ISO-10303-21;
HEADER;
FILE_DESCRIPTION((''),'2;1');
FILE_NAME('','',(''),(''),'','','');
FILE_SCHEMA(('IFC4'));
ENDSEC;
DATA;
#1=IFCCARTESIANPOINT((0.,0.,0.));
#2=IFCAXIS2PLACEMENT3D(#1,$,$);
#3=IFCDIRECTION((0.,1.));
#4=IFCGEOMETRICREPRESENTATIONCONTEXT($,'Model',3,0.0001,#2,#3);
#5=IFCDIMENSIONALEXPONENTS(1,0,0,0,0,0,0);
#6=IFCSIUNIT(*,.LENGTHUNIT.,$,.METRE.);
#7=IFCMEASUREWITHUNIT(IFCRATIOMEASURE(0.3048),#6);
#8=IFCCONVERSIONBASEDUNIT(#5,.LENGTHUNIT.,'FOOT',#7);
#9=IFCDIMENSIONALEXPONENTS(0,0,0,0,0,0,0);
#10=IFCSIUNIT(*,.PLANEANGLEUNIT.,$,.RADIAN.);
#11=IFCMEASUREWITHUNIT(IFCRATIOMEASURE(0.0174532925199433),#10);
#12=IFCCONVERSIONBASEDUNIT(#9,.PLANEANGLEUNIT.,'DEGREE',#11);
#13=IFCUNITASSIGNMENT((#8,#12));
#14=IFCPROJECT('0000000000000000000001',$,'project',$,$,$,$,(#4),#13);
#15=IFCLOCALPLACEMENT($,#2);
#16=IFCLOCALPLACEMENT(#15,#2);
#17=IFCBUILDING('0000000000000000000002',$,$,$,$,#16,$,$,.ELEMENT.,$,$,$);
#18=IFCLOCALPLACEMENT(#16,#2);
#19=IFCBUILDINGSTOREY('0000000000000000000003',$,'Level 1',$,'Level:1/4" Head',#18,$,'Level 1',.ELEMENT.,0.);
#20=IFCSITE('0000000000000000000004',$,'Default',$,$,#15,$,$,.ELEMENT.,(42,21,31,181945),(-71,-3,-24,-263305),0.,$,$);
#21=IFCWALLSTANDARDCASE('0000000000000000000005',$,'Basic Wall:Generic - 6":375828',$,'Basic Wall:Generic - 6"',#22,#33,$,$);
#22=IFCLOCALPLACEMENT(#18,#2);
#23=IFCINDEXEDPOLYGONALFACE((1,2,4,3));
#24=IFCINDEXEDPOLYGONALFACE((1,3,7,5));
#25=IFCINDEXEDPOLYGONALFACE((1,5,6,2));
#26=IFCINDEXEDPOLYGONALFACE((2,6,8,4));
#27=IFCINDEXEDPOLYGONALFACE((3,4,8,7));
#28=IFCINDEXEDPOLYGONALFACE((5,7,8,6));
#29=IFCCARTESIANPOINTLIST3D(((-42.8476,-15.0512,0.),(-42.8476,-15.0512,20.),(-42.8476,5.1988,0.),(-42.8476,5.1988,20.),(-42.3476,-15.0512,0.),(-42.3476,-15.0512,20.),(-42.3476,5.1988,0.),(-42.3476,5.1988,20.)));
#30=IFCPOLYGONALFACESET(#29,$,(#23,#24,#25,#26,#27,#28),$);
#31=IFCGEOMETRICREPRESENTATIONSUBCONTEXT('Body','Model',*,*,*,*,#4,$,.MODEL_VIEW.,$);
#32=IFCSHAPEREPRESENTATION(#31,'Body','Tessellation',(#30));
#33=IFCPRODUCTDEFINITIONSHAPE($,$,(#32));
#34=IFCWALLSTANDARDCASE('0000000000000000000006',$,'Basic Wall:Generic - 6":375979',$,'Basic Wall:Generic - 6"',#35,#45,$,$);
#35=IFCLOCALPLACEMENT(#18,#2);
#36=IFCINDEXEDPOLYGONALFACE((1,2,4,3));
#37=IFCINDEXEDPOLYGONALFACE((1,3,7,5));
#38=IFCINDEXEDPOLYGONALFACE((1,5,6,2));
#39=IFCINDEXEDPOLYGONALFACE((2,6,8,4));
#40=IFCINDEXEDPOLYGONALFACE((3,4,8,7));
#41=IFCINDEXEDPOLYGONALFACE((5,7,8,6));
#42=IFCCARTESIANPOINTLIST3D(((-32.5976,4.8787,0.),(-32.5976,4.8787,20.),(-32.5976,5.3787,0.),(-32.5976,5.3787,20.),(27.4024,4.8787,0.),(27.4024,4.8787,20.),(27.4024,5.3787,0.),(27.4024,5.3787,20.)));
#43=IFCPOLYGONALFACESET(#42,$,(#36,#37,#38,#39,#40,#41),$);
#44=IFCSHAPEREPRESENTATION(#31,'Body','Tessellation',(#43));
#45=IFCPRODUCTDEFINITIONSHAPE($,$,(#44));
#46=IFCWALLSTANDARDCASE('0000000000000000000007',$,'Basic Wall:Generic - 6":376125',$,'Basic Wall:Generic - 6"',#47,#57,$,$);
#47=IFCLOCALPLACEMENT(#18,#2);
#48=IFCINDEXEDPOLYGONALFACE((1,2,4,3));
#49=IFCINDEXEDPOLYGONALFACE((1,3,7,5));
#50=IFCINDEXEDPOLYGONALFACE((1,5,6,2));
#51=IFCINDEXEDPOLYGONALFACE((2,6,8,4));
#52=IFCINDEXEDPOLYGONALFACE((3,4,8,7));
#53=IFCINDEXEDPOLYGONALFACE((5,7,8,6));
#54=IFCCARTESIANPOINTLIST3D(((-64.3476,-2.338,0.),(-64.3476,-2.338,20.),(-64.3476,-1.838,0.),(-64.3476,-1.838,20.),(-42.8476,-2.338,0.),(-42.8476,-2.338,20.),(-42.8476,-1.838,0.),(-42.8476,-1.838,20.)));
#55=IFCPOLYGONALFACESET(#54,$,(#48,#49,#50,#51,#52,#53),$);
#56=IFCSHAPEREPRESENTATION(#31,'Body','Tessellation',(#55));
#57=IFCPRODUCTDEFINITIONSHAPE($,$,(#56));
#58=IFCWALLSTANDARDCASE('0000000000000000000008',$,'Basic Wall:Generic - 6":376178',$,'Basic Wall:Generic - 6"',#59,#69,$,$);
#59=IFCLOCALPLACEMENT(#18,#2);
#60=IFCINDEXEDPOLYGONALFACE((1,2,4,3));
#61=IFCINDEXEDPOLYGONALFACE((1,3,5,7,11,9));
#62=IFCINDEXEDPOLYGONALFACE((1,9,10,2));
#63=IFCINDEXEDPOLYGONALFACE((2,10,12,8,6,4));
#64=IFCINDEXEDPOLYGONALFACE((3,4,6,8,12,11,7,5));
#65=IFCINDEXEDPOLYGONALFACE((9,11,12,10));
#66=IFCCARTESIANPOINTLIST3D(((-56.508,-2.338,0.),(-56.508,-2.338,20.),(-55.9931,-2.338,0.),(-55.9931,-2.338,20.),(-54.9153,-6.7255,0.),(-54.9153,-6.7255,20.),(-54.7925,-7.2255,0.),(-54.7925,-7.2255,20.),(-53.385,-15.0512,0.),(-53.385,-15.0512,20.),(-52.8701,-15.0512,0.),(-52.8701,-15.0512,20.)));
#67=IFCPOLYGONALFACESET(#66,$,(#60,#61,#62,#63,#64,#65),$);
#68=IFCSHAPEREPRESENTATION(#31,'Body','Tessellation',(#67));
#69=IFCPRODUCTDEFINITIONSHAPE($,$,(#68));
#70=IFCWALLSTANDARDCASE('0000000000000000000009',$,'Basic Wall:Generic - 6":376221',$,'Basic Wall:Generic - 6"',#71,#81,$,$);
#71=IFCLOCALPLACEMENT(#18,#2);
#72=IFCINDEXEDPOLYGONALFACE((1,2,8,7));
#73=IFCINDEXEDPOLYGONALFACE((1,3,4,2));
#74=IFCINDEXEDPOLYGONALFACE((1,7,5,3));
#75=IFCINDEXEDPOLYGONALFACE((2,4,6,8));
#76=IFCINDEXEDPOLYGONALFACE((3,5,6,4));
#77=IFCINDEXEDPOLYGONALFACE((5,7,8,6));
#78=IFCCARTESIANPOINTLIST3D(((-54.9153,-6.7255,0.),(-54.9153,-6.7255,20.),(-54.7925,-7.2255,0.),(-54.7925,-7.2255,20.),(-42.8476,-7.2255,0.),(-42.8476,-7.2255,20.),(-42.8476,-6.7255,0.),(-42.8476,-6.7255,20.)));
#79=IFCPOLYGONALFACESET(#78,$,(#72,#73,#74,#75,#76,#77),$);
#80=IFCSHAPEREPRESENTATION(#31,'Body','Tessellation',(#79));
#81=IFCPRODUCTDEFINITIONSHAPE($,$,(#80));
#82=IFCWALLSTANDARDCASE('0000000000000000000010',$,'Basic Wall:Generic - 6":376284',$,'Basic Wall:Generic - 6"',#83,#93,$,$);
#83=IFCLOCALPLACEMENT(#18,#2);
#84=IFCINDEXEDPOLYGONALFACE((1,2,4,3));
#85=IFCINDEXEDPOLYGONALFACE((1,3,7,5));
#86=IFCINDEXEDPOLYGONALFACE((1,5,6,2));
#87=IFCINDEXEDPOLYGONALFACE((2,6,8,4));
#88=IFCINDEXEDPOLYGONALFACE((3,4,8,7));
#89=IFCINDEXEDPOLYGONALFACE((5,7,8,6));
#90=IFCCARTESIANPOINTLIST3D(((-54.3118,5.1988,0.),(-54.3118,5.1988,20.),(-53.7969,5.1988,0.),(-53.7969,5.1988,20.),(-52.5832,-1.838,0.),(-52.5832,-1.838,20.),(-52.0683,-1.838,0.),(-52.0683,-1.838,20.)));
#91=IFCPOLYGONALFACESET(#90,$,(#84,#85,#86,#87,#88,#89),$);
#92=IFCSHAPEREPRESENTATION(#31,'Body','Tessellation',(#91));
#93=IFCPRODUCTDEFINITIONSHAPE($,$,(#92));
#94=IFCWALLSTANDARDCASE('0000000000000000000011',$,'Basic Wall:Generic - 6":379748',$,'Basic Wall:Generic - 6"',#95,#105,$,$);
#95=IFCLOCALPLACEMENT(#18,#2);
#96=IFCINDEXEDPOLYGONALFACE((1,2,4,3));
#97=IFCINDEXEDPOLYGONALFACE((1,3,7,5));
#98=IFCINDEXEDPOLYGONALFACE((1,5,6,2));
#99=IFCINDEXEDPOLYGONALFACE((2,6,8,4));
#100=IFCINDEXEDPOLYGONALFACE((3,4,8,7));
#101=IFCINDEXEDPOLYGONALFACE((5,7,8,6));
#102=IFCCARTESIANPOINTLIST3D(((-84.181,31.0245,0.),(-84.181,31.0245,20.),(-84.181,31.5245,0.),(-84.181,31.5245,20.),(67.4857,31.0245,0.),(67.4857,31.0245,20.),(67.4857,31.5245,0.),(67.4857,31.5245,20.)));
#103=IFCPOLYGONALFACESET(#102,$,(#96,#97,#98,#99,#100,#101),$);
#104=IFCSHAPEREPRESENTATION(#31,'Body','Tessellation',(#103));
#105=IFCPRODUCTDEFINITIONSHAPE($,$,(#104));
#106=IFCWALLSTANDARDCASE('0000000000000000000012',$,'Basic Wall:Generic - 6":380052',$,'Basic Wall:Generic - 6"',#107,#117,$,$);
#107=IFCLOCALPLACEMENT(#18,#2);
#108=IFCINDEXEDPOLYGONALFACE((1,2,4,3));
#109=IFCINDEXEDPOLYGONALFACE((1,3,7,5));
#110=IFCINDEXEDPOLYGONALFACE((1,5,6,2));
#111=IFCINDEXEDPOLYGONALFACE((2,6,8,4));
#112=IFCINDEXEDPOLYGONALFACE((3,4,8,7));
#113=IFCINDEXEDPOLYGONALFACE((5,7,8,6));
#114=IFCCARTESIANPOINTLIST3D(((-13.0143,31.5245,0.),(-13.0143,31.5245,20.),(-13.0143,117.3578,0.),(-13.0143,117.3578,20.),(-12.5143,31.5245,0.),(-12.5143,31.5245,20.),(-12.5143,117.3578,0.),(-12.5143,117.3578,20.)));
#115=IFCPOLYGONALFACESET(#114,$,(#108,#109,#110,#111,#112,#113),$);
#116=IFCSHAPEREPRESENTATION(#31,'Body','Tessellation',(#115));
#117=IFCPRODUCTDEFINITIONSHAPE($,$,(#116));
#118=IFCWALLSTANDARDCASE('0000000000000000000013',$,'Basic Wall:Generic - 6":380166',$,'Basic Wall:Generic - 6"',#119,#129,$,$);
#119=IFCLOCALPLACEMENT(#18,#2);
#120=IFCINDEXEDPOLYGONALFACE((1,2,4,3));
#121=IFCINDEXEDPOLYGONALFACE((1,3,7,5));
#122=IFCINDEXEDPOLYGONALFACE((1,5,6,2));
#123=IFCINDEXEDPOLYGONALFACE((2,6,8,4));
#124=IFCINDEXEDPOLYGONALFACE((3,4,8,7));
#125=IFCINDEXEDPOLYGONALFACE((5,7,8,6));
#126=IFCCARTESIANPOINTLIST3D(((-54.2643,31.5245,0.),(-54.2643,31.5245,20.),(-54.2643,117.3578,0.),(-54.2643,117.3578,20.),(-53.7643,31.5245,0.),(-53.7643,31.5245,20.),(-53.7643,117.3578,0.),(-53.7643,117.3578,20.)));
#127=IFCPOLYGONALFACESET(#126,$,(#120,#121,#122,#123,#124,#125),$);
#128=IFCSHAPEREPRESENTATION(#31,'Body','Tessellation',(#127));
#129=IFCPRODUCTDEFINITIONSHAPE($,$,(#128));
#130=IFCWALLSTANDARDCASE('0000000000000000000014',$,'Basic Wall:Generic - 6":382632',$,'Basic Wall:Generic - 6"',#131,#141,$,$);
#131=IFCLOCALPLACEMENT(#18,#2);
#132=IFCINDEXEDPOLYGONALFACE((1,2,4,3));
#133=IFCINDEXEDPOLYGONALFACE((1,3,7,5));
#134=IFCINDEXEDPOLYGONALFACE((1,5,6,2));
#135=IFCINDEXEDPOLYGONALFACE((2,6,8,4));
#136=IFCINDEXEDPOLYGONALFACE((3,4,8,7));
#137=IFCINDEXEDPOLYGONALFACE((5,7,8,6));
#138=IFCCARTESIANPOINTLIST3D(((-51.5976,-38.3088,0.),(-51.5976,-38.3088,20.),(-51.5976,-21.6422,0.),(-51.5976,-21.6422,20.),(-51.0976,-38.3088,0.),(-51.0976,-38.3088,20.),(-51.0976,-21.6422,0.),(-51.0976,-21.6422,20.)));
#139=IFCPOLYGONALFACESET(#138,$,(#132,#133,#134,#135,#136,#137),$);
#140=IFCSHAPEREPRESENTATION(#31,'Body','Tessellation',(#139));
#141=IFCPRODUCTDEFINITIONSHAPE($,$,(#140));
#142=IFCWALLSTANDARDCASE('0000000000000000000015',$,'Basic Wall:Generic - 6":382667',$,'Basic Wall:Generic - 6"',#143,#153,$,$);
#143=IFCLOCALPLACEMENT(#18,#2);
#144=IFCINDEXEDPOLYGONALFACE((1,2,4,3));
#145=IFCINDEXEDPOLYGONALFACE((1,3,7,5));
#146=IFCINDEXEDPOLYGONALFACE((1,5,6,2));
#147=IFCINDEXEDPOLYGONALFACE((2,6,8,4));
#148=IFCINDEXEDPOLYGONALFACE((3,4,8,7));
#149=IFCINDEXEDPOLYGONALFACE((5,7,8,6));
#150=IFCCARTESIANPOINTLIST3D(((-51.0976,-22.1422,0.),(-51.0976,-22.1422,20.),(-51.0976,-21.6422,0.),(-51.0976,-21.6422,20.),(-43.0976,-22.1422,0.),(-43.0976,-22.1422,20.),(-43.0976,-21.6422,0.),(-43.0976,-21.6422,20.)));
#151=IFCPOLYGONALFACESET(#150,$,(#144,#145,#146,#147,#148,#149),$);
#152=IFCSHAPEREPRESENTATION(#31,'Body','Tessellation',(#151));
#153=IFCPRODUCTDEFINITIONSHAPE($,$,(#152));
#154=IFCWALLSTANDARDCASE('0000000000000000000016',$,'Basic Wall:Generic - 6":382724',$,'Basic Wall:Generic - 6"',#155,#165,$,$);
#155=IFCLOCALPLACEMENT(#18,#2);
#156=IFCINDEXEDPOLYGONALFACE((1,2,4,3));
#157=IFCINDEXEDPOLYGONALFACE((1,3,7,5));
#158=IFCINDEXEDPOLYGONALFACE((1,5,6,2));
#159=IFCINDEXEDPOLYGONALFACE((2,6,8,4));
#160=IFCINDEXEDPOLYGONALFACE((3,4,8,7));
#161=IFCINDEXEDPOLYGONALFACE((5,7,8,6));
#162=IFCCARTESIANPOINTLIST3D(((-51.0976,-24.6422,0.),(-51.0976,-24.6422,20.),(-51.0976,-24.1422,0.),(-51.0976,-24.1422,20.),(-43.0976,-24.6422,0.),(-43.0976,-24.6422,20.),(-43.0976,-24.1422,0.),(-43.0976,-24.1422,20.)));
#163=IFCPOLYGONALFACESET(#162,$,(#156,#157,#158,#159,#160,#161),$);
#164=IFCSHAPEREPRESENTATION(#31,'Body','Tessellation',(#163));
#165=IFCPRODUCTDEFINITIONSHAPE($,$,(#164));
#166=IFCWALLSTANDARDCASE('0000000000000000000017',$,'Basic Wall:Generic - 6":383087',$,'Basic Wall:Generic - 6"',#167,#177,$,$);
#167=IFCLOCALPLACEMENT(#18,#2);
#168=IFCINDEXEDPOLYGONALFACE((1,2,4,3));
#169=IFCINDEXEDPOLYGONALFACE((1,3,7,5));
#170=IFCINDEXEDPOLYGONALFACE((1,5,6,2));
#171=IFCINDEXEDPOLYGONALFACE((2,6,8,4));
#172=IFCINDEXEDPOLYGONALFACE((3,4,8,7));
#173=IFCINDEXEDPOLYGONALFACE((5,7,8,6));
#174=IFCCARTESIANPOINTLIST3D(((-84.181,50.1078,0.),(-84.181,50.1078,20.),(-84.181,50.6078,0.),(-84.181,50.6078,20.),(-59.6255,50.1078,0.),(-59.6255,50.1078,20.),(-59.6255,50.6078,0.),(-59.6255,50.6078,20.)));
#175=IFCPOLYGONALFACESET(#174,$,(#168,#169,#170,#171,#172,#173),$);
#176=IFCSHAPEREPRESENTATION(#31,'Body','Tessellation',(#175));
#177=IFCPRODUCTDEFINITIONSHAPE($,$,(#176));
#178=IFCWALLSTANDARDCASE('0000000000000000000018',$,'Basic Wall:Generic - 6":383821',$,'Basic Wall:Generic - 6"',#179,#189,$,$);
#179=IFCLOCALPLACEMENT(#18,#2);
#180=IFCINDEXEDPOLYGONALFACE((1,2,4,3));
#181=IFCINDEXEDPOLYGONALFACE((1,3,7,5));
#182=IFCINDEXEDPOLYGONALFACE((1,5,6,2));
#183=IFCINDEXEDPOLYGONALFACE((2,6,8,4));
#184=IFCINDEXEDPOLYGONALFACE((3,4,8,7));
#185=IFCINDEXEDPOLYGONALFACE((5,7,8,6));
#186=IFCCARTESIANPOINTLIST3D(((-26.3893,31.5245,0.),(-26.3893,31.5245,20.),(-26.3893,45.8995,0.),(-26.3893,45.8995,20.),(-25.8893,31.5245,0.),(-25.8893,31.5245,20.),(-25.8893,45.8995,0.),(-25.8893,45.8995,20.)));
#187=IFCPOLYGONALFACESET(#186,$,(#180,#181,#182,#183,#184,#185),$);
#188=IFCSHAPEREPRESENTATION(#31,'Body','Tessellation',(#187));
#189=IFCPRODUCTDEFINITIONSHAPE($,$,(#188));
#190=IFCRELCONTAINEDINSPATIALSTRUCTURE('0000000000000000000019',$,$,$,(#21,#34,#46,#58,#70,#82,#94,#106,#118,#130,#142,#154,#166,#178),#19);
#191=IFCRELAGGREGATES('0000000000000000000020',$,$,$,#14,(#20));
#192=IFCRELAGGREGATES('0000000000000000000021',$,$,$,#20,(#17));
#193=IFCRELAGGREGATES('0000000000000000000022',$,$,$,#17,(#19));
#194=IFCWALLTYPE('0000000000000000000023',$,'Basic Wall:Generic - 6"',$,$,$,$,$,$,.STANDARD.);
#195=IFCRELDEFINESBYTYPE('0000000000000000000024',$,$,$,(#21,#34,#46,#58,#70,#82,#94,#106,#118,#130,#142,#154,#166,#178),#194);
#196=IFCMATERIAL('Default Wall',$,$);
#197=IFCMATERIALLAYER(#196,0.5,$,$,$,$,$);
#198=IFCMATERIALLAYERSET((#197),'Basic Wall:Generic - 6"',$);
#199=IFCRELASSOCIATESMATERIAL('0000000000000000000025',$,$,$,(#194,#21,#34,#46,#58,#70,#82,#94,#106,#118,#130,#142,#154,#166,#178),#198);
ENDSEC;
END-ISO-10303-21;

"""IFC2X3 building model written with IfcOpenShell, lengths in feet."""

from ifc_helpers import new_model, entity, si_unit, converted_unit, direction, frame, frame_2d, origin, place, context, subcontext, project, spatial, polyline, rectangle, outline, extrude, material, layer, layer_set, layer_usage, type_object, element, save


model = new_model("IFC2X3")

# Units and contexts
model_context = context("Model", 3, precision=0.0001, world=origin(), true_north=direction((0.0, 1.0)))
body_context = subcontext(model_context, "Body", "Model", "MODEL_VIEW")
ifc_project = project(units=[converted_unit("LENGTHUNIT", "FOOT", entity("IfcRatioMeasure", 0.3048), si_unit("LENGTHUNIT", "METRE"), dimensions=[1, 0, 0, 0, 0, 0, 0]), converted_unit("PLANEANGLEUNIT", "DEGREE", entity("IfcRatioMeasure", 0.0174532925199433), si_unit("PLANEANGLEUNIT", "RADIAN"), dimensions=[0, 0, 0, 0, 0, 0, 0])], contexts=[model_context])

# Site, building, storey
site_placement = place(None, origin())
site = spatial("IfcSite", under=ifc_project, at=site_placement, Name="Default", CompositionType="ELEMENT", RefLatitude=(42, 21, 31, 181945), RefLongitude=(-71, -3, -24, -263305), RefElevation=0.0)
building_placement = place(site_placement, origin())
building = spatial("IfcBuilding", under=site, at=building_placement, CompositionType="ELEMENT")
storey_placement = place(building_placement, origin())
storey = spatial("IfcBuildingStorey", under=building, at=storey_placement, Name="Level 1", ObjectType="Level:1/4\" Head", LongName="Level 1", CompositionType="ELEMENT", Elevation=0.0)

# Walls
ifc_material = material(Name="Default Wall")
ifc_layer_1 = layer(ifc_material, 0.5)
ifc_layer_set_1 = layer_set([ifc_layer_1], Name="Basic Wall:Generic - 6\"")
wall_type_1 = type_object("IfcWallType", Name="Basic Wall:Generic - 6\"", PredefinedType="STANDARD", material=ifc_layer_set_1)
ifc_layer_usage_1 = layer_usage(ifc_layer_set_1, "AXIS2", "NEGATIVE", 0.25)
wall_1_placement = place(storey_placement, frame((-42.5976, 5.1988, 0.0), z_axis=(0.0, 0.0, 1.0), x_axis=(0.0, -1.0, 0.0)))
element("IfcWallStandardCase", 1, at=wall_1_placement, inside=storey, type_object=wall_type_1, material=ifc_layer_usage_1, Name="Basic Wall:Generic - 6\":375828", ObjectType="Basic Wall:Generic - 6\"", context=body_context, shape_type="SweptSolid", body=[
    extrude(rectangle(XDim=20.25, YDim=0.5, at=frame_2d((10.125, 0.0), x_axis=(-1.0, 0.0))), origin(), (0.0, 0.0, 1.0), 20.0),
])
ifc_layer_usage_2 = layer_usage(ifc_layer_set_1, "AXIS2", "NEGATIVE", 0.25)
wall_2_placement = place(storey_placement, frame((-32.5976, 5.1287, 0.0)))
element("IfcWallStandardCase", 2, at=wall_2_placement, inside=storey, type_object=wall_type_1, material=ifc_layer_usage_2, Name="Basic Wall:Generic - 6\":375979", ObjectType="Basic Wall:Generic - 6\"", context=body_context, shape_type="SweptSolid", body=[
    extrude(rectangle(XDim=60.0, YDim=0.5, at=frame_2d((30.0, 0.0), x_axis=(-1.0, 0.0))), origin(), (0.0, 0.0, 1.0), 20.0),
])
ifc_layer_usage_3 = layer_usage(ifc_layer_set_1, "AXIS2", "NEGATIVE", 0.25)
wall_3_placement = place(storey_placement, frame((-64.3476, -2.088, 0.0)))
element("IfcWallStandardCase", 3, at=wall_3_placement, inside=storey, type_object=wall_type_1, material=ifc_layer_usage_3, Name="Basic Wall:Generic - 6\":376125", ObjectType="Basic Wall:Generic - 6\"", context=body_context, shape_type="SweptSolid", body=[
    extrude(rectangle(XDim=21.5, YDim=0.5, at=frame_2d((10.75, 0.0), x_axis=(-1.0, 0.0))), origin(), (0.0, 0.0, 1.0), 20.0),
])
ifc_layer_usage_4 = layer_usage(ifc_layer_set_1, "AXIS2", "NEGATIVE", 0.25)
wall_4_placement = place(storey_placement, frame((-53.1129, -15.1108, 0.0), z_axis=(0.0, 0.0, 1.0), x_axis=(-0.23856, 0.971128, 0.0)))
element("IfcWallStandardCase", 4, at=wall_4_placement, inside=storey, type_object=wall_type_1, material=ifc_layer_usage_4, Name="Basic Wall:Generic - 6\":376178", ObjectType="Basic Wall:Generic - 6\"", context=body_context, shape_type="SweptSolid", body=[
    extrude(outline(polyline([(13.0911, -0.25), (13.2139, 0.25), (0.1228, 0.25), (0.0, -0.25), (8.0583, -0.25), (8.5732, -0.25), (13.0911, -0.25)])), origin(), (0.0, 0.0, 1.0), 20.0),
])
ifc_layer_usage_5 = layer_usage(ifc_layer_set_1, "AXIS2", "NEGATIVE", 0.25)
wall_5_placement = place(storey_placement, frame((-42.8476, -6.9755, 0.0), z_axis=(0.0, 0.0, 1.0), x_axis=(-1.0, 0.0, 0.0)))
element("IfcWallStandardCase", 5, at=wall_5_placement, inside=storey, type_object=wall_type_1, material=ifc_layer_usage_5, Name="Basic Wall:Generic - 6\":376221", ObjectType="Basic Wall:Generic - 6\"", context=body_context, shape_type="SweptSolid", body=[
    extrude(outline(polyline([(12.0677, -0.25), (11.9449, 0.25), (0.0, 0.25), (0.0, -0.25), (12.0677, -0.25)])), origin(), (0.0, 0.0, 1.0), 20.0),
])
ifc_layer_usage_6 = layer_usage(ifc_layer_set_1, "AXIS2", "NEGATIVE", 0.25)
wall_6_placement = place(storey_placement, frame((-52.3111, -1.8977, 0.0), z_axis=(0.0, 0.0, 1.0), x_axis=(-0.23856, 0.971128, 0.0)))
element("IfcWallStandardCase", 6, at=wall_6_placement, inside=storey, type_object=wall_type_1, material=ifc_layer_usage_6, Name="Basic Wall:Generic - 6\":376284", ObjectType="Basic Wall:Generic - 6\"", context=body_context, shape_type="SweptSolid", body=[
    extrude(outline(polyline([(7.2461, -0.25), (7.3689, 0.25), (0.1228, 0.25), (0.0, -0.25), (7.2461, -0.25)])), origin(), (0.0, 0.0, 1.0), 20.0),
])
ifc_layer_usage_7 = layer_usage(ifc_layer_set_1, "AXIS2", "NEGATIVE", 0.25)
wall_7_placement = place(storey_placement, frame((-84.181, 31.2745, 0.0)))
element("IfcWallStandardCase", 7, at=wall_7_placement, inside=storey, type_object=wall_type_1, material=ifc_layer_usage_7, Name="Basic Wall:Generic - 6\":379748", ObjectType="Basic Wall:Generic - 6\"", context=body_context, shape_type="SweptSolid", body=[
    extrude(rectangle(XDim=151.6667, YDim=0.5, at=frame_2d((75.8333, 0.0), x_axis=(-1.0, 0.0))), origin(), (0.0, 0.0, 1.0), 20.0),
])
ifc_layer_usage_8 = layer_usage(ifc_layer_set_1, "AXIS2", "NEGATIVE", 0.25)
wall_8_placement = place(storey_placement, frame((-12.7643, 31.5245, 0.0), z_axis=(0.0, 0.0, 1.0), x_axis=(0.0, 1.0, 0.0)))
element("IfcWallStandardCase", 8, at=wall_8_placement, inside=storey, type_object=wall_type_1, material=ifc_layer_usage_8, Name="Basic Wall:Generic - 6\":380052", ObjectType="Basic Wall:Generic - 6\"", context=body_context, shape_type="SweptSolid", body=[
    extrude(rectangle(XDim=85.8333, YDim=0.5, at=frame_2d((42.9167, 0.0), x_axis=(-1.0, 0.0))), origin(), (0.0, 0.0, 1.0), 20.0),
])
ifc_layer_usage_9 = layer_usage(ifc_layer_set_1, "AXIS2", "NEGATIVE", 0.25)
wall_9_placement = place(storey_placement, frame((-54.0143, 31.5245, 0.0), z_axis=(0.0, 0.0, 1.0), x_axis=(0.0, 1.0, 0.0)))
element("IfcWallStandardCase", 9, at=wall_9_placement, inside=storey, type_object=wall_type_1, material=ifc_layer_usage_9, Name="Basic Wall:Generic - 6\":380166", ObjectType="Basic Wall:Generic - 6\"", context=body_context, shape_type="SweptSolid", body=[
    extrude(rectangle(XDim=85.8333, YDim=0.5, at=frame_2d((42.9167, 0.0), x_axis=(-1.0, 0.0))), origin(), (0.0, 0.0, 1.0), 20.0),
])
ifc_layer_usage_10 = layer_usage(ifc_layer_set_1, "AXIS2", "NEGATIVE", 0.25)
wall_10_placement = place(storey_placement, frame((-51.3476, -38.3088, 0.0), z_axis=(0.0, 0.0, 1.0), x_axis=(0.0, 1.0, 0.0)))
element("IfcWallStandardCase", 10, at=wall_10_placement, inside=storey, type_object=wall_type_1, material=ifc_layer_usage_10, Name="Basic Wall:Generic - 6\":382632", ObjectType="Basic Wall:Generic - 6\"", context=body_context, shape_type="SweptSolid", body=[
    extrude(rectangle(XDim=16.6667, YDim=0.5, at=frame_2d((8.3333, 0.0), x_axis=(-1.0, 0.0))), origin(), (0.0, 0.0, 1.0), 20.0),
])
ifc_layer_usage_11 = layer_usage(ifc_layer_set_1, "AXIS2", "NEGATIVE", 0.25)
wall_11_placement = place(storey_placement, frame((-51.0976, -21.8922, 0.0)))
element("IfcWallStandardCase", 11, at=wall_11_placement, inside=storey, type_object=wall_type_1, material=ifc_layer_usage_11, Name="Basic Wall:Generic - 6\":382667", ObjectType="Basic Wall:Generic - 6\"", context=body_context, shape_type="SweptSolid", body=[
    extrude(rectangle(XDim=8.0, YDim=0.5, at=frame_2d((4.0, 0.0), x_axis=(-1.0, 0.0))), origin(), (0.0, 0.0, 1.0), 20.0),
])
ifc_layer_usage_12 = layer_usage(ifc_layer_set_1, "AXIS2", "NEGATIVE", 0.25)
wall_12_placement = place(storey_placement, frame((-43.0976, -24.3922, 0.0), z_axis=(0.0, 0.0, 1.0), x_axis=(-1.0, 0.0, 0.0)))
element("IfcWallStandardCase", 12, at=wall_12_placement, inside=storey, type_object=wall_type_1, material=ifc_layer_usage_12, Name="Basic Wall:Generic - 6\":382724", ObjectType="Basic Wall:Generic - 6\"", context=body_context, shape_type="SweptSolid", body=[
    extrude(rectangle(XDim=8.0, YDim=0.5, at=frame_2d((4.0, 0.0), x_axis=(-1.0, 0.0))), origin(), (0.0, 0.0, 1.0), 20.0),
])
ifc_layer_usage_13 = layer_usage(ifc_layer_set_1, "AXIS2", "NEGATIVE", 0.25)
wall_13_placement = place(storey_placement, frame((-59.6255, 50.3578, 0.0), z_axis=(0.0, 0.0, 1.0), x_axis=(-1.0, 0.0, 0.0)))
element("IfcWallStandardCase", 13, at=wall_13_placement, inside=storey, type_object=wall_type_1, material=ifc_layer_usage_13, Name="Basic Wall:Generic - 6\":383087", ObjectType="Basic Wall:Generic - 6\"", context=body_context, shape_type="SweptSolid", body=[
    extrude(rectangle(XDim=24.5555, YDim=0.5, at=frame_2d((12.2778, 0.0), x_axis=(-1.0, 0.0))), origin(), (0.0, 0.0, 1.0), 20.0),
])
ifc_layer_usage_14 = layer_usage(ifc_layer_set_1, "AXIS2", "NEGATIVE", 0.25)
wall_14_placement = place(storey_placement, frame((-26.1393, 31.5245, 0.0), z_axis=(0.0, 0.0, 1.0), x_axis=(0.0, 1.0, 0.0)))
element("IfcWallStandardCase", 14, at=wall_14_placement, inside=storey, type_object=wall_type_1, material=ifc_layer_usage_14, Name="Basic Wall:Generic - 6\":383821", ObjectType="Basic Wall:Generic - 6\"", context=body_context, shape_type="SweptSolid", body=[
    extrude(rectangle(XDim=14.375, YDim=0.5, at=frame_2d((7.1875, 0.0), x_axis=(-1.0, 0.0))), origin(), (0.0, 0.0, 1.0), 20.0),
])

save(model, "model.ifc")
